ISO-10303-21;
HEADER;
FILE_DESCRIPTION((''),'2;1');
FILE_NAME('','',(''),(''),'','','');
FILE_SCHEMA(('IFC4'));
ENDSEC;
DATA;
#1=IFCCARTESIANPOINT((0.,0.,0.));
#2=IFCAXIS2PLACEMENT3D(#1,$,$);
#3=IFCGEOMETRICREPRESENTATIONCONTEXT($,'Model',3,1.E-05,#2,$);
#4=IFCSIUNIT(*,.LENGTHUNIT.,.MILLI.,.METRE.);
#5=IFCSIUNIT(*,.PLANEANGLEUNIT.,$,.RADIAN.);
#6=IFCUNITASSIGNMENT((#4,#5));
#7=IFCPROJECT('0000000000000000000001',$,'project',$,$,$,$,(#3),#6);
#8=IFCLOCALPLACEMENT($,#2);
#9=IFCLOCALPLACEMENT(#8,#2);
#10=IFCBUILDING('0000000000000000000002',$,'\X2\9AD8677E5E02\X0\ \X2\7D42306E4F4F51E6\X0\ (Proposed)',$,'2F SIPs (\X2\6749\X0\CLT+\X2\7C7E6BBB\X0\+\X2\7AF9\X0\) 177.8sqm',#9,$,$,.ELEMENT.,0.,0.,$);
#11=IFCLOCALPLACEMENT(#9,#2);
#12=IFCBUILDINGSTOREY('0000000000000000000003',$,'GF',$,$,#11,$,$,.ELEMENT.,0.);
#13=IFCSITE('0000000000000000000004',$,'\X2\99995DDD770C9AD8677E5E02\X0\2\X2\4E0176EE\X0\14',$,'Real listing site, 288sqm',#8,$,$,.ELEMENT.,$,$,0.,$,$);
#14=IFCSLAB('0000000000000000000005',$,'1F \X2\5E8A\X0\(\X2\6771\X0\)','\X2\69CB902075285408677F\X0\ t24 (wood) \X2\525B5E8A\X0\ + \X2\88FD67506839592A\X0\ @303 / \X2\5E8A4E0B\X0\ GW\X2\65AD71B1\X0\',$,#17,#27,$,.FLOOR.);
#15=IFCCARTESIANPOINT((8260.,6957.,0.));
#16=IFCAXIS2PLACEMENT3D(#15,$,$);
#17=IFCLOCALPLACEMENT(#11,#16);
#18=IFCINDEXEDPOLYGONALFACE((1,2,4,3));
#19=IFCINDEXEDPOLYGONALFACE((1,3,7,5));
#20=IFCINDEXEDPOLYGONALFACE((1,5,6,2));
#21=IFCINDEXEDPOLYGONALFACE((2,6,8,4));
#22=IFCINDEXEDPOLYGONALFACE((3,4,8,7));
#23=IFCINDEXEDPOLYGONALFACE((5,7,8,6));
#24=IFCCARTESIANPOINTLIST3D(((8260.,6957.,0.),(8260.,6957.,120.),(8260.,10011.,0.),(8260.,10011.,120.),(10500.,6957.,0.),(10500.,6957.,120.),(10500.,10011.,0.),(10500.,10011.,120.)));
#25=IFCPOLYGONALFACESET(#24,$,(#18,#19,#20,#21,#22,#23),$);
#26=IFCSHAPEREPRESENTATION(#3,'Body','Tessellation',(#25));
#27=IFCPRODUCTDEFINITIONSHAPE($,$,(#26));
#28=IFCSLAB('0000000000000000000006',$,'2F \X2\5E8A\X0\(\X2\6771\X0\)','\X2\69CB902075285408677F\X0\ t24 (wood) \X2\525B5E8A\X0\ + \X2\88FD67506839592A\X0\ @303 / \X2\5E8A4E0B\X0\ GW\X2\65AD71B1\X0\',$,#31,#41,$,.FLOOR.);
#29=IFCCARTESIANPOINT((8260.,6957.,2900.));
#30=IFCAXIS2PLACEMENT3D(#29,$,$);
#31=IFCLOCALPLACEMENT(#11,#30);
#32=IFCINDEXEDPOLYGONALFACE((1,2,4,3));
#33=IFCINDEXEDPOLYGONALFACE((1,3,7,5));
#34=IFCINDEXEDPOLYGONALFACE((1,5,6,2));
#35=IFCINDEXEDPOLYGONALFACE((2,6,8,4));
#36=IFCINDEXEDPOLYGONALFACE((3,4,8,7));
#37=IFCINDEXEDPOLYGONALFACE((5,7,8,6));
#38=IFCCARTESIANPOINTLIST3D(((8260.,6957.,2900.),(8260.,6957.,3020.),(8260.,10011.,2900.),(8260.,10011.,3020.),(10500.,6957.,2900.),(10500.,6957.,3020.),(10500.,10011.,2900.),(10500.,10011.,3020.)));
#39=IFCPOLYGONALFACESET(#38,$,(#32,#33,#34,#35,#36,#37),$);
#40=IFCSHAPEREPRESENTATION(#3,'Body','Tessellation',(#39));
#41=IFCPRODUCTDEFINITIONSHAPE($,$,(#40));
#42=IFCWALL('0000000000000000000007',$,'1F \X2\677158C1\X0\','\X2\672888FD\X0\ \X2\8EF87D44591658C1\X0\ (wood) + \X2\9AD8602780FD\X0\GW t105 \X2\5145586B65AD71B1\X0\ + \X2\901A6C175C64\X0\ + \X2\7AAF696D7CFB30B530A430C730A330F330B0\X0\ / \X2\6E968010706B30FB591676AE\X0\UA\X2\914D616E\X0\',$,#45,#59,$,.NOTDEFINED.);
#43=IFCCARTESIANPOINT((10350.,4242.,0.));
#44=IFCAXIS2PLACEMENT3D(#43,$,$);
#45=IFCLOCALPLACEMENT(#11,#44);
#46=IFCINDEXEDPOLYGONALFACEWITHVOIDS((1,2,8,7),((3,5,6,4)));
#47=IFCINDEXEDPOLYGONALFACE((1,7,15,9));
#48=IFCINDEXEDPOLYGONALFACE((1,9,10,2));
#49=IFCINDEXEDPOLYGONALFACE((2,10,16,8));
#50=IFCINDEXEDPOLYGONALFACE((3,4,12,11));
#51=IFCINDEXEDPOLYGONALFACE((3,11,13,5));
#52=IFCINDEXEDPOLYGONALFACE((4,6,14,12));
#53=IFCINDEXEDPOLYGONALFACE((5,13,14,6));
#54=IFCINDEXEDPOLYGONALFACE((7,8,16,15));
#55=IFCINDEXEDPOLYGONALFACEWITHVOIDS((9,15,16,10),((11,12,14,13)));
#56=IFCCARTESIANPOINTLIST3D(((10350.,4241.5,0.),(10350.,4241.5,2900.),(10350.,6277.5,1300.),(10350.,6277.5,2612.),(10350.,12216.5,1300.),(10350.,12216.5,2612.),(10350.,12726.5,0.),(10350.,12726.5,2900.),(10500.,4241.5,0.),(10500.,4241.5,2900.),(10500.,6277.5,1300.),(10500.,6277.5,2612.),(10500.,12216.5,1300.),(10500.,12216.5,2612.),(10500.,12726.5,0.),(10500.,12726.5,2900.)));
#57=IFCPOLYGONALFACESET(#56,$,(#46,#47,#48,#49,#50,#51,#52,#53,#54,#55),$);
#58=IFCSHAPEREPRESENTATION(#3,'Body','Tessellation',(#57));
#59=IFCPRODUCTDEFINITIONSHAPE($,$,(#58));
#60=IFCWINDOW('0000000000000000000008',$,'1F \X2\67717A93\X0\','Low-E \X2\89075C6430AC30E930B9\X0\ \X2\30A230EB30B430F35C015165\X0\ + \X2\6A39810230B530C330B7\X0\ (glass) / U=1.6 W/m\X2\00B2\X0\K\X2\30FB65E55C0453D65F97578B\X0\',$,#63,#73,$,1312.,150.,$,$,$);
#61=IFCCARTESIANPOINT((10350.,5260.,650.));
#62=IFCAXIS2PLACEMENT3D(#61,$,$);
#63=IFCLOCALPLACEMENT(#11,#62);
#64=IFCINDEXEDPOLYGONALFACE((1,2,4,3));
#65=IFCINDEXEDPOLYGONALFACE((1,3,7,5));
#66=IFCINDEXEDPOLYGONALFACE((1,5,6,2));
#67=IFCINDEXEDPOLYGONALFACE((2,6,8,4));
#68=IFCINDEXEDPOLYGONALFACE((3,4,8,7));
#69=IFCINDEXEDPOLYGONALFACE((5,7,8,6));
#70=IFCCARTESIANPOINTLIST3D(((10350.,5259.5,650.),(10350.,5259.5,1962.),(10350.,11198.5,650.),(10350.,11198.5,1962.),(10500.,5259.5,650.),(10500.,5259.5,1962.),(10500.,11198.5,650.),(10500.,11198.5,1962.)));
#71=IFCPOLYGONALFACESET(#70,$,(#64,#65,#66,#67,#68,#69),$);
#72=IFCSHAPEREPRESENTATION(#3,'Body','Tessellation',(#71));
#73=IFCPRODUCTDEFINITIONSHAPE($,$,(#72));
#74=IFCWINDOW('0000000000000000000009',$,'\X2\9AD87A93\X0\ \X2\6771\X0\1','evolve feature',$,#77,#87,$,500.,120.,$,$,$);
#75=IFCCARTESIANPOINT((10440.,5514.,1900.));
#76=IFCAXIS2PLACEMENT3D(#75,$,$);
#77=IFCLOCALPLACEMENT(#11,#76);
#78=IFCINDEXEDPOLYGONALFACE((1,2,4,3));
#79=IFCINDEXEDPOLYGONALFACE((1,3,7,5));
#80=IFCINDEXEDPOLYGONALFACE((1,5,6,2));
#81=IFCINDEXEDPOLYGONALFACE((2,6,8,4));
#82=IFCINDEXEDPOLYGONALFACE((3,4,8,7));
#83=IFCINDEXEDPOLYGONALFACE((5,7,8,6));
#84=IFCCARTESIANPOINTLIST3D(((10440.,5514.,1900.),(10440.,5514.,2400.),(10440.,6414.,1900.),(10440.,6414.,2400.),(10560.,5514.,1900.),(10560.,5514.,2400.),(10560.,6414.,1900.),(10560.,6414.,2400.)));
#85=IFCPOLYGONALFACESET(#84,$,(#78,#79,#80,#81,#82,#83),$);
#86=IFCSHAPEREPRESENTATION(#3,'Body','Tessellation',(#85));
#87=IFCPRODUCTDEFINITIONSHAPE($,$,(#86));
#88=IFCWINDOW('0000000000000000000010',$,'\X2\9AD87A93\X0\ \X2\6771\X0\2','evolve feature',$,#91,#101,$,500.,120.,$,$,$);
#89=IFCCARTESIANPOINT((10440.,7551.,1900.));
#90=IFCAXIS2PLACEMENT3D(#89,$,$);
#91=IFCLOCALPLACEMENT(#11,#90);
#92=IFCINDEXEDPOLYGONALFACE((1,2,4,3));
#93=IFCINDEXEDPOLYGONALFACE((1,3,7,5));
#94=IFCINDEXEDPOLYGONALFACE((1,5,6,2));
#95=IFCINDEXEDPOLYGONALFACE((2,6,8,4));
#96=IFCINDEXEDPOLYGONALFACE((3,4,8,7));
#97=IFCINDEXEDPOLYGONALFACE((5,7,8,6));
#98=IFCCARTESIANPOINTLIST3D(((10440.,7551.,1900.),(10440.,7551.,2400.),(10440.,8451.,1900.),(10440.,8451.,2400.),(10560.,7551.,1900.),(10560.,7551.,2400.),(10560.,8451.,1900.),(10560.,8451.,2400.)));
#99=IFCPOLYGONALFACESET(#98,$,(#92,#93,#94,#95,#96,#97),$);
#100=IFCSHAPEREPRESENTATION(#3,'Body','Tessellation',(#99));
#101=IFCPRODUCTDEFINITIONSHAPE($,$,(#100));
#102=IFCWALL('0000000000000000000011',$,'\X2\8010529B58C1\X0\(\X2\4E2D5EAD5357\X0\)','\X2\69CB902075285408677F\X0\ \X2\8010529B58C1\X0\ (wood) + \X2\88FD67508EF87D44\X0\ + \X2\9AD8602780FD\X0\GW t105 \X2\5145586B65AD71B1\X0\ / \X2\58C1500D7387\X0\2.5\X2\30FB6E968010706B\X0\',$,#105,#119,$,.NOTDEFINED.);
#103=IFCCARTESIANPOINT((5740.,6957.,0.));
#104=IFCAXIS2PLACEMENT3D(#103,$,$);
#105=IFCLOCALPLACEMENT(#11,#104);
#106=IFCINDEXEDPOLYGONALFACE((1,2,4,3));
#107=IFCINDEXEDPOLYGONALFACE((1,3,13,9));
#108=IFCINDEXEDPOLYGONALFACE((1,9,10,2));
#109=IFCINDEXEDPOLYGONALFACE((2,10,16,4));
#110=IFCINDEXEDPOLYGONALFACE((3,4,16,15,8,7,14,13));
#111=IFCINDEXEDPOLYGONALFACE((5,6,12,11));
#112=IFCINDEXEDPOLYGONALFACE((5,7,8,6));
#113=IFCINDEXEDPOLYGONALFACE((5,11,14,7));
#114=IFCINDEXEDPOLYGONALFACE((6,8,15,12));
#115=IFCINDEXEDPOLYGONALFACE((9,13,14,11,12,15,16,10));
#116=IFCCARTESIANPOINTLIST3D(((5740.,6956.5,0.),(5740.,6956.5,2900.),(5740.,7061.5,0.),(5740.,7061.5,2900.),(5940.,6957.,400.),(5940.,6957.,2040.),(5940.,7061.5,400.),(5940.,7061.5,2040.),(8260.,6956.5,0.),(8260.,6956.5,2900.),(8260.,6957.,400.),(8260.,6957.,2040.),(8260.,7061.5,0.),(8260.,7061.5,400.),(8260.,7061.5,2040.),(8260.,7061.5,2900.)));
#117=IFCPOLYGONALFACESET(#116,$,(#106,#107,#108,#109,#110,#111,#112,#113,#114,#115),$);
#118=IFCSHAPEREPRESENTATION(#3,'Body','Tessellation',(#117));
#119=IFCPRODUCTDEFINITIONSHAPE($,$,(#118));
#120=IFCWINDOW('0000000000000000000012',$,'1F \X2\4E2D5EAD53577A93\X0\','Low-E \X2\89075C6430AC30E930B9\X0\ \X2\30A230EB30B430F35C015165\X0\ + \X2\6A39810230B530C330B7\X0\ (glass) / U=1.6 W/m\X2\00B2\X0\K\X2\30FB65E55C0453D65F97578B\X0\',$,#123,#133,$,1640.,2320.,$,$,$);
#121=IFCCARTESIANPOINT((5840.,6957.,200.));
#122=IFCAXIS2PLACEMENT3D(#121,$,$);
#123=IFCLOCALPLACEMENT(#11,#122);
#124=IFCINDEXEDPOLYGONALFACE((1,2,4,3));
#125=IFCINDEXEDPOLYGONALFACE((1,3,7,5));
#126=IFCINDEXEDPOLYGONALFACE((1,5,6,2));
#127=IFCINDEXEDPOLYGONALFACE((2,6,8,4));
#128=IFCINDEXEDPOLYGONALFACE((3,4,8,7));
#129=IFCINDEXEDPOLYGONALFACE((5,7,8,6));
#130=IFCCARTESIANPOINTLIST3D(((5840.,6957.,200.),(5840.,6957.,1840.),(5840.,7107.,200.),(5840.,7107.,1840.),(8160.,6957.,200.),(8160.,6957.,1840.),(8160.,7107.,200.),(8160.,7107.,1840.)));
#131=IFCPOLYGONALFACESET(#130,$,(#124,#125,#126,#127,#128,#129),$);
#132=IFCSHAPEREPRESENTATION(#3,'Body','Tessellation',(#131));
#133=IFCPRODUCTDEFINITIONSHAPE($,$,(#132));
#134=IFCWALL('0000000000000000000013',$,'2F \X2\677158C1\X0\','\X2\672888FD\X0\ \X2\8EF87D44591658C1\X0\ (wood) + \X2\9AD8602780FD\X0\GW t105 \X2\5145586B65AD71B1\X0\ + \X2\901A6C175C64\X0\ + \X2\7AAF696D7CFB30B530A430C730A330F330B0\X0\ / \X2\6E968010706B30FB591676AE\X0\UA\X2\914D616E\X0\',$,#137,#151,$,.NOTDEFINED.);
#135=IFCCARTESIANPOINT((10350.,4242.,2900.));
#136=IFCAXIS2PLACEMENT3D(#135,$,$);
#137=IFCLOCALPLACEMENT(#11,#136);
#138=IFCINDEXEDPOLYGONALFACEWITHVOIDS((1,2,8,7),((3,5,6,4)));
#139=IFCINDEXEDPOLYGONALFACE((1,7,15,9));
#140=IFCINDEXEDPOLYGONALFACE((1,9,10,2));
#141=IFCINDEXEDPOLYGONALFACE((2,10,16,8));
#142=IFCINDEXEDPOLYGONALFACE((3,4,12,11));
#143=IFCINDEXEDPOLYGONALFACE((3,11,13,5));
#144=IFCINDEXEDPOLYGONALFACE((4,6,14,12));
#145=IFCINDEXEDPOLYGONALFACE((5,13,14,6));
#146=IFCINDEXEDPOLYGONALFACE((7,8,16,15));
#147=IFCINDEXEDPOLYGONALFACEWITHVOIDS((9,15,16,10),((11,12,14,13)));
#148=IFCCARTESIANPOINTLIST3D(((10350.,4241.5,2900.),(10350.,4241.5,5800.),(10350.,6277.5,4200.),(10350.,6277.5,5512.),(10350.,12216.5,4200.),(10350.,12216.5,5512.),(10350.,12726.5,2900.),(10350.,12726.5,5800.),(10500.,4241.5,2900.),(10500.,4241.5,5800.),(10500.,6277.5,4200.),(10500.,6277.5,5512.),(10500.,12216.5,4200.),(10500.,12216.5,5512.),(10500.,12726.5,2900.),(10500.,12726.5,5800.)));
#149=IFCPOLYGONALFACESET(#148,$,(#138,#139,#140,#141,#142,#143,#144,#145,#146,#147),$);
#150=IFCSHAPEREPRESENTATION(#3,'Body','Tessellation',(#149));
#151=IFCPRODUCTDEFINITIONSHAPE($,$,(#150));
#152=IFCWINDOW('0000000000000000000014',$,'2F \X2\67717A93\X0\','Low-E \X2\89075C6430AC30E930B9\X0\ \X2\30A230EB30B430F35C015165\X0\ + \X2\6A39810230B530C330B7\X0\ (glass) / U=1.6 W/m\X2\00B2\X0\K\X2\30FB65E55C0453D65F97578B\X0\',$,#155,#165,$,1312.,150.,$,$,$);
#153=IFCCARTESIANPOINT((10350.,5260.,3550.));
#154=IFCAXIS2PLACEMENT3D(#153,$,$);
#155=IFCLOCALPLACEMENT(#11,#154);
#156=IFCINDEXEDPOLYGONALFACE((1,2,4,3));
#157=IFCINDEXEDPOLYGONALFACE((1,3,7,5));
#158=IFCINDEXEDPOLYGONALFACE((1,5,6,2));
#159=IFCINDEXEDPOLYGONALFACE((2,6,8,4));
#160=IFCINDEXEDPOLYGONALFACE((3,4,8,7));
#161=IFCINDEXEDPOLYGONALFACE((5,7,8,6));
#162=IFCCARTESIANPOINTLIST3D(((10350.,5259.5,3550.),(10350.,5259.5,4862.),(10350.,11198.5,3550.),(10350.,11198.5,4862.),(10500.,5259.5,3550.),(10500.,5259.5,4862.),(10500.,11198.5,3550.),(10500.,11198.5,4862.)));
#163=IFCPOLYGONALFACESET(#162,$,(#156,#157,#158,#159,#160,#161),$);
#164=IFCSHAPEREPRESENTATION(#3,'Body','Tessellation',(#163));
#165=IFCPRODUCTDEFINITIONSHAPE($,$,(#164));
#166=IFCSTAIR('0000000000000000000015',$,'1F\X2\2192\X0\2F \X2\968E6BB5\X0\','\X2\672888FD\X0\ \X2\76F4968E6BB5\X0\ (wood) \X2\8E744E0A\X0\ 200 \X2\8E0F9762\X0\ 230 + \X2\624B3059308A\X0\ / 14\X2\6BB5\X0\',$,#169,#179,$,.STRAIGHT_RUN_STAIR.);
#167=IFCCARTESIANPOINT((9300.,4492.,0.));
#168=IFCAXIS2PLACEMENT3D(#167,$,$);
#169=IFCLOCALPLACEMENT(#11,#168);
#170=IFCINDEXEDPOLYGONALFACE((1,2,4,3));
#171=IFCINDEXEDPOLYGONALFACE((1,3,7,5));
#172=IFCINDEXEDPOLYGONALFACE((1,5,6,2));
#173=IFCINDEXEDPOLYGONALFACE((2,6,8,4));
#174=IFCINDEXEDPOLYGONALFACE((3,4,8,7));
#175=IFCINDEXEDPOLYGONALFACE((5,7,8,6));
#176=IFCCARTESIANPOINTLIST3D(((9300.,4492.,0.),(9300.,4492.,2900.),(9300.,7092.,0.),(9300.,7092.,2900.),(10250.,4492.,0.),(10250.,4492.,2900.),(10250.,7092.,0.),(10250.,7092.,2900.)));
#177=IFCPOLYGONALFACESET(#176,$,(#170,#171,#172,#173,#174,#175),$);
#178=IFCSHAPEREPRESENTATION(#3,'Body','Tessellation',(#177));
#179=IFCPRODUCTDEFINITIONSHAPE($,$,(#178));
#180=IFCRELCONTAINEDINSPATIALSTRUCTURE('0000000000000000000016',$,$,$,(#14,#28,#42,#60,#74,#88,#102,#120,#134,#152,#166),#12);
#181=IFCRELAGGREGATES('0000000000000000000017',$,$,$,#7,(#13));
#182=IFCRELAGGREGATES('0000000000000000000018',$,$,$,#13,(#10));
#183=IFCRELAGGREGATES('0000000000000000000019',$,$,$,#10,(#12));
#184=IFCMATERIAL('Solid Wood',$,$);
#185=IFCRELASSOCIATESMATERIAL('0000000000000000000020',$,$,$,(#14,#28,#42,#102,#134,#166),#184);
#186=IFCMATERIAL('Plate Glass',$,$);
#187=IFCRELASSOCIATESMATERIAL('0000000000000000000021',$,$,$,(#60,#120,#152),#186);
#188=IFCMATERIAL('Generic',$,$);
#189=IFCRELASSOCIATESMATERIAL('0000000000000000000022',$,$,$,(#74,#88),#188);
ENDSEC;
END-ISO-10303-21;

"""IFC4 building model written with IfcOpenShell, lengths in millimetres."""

from ifc_helpers import new_model, si_unit, frame, frame_2d, origin, place, context, project, spatial, rectangle, extrude, material, element, fill, save


model = new_model("IFC4")

# Units and contexts
model_context = context("Model", 3, precision=1e-05, world=origin())
ifc_project = project(units=[si_unit("LENGTHUNIT", "METRE", prefix="MILLI"), si_unit("PLANEANGLEUNIT", "RADIAN")], contexts=[model_context])

# Site, building, storey
site_placement = place(None, origin())
site = spatial("IfcSite", under=ifc_project, at=site_placement, Name="香川県高松市2丁目14", ObjectType="Real listing site, 288sqm", CompositionType="ELEMENT", RefElevation=0.0)
building_placement = place(site_placement, origin())
building = spatial("IfcBuilding", under=site, at=building_placement, Name="高松市 終の住処 (Proposed)", ObjectType="2F SIPs (杉CLT+籾殻+竹) 177.8sqm", CompositionType="ELEMENT", ElevationOfRefHeight=0.0, ElevationOfTerrain=0.0)
storey_placement = place(building_placement, origin())
storey = spatial("IfcBuildingStorey", under=building, at=storey_placement, Name="GF", CompositionType="ELEMENT", Elevation=0.0)

# Slabs
ifc_material_1 = material(Name="Solid Wood")
slab_1_placement = place(storey_placement, frame((8260.0, 6957.0, 0.0)))
element("IfcSlab", 1, at=slab_1_placement, inside=storey, material=ifc_material_1, Name="1F 床(東)", Description="構造用合板 t24 (wood) 剛床 + 製材根太 @303 / 床下 GW断熱", PredefinedType="FLOOR", context=model_context, shape_type="SweptSolid", body=[
    extrude(rectangle(XDim=2240.0, YDim=3054.0, at=frame_2d((1120.0, 1527.0))), frame((8260.0, 6957.0, 0.0)), (0.0, 0.0, 1.0), 120.0),
])
slab_2_placement = place(storey_placement, frame((8260.0, 6957.0, 2900.0)))
element("IfcSlab", 2, at=slab_2_placement, inside=storey, material=ifc_material_1, Name="2F 床(東)", Description="構造用合板 t24 (wood) 剛床 + 製材根太 @303 / 床下 GW断熱", PredefinedType="FLOOR", context=model_context, shape_type="SweptSolid", body=[
    extrude(rectangle(XDim=2240.0, YDim=3054.0, at=frame_2d((1120.0, 1527.0))), frame((8260.0, 6957.0, 2900.0)), (0.0, 0.0, 1.0), 120.0),
])

# Wall, openings, windows
wall_1_placement = place(storey_placement, frame((10350.0, 4242.0, 0.0)))
wall_1 = element("IfcWall", 3, at=wall_1_placement, inside=storey, material=ifc_material_1, Name="1F 東壁", Description="木製 軸組外壁 (wood) + 高性能GW t105 充填断熱 + 通気層 + 窯業系サイディング / 準耐火・外皮UA配慮", PredefinedType="NOTDEFINED", context=model_context, shape_type="SweptSolid", body=[
    extrude(rectangle(XDim=150.0, YDim=8485.0, at=frame_2d((75.0, 4242.0))), frame((10350.0, 4242.0, 0.0)), (0.0, 0.0, 1.0), 2900.0),
])
opening_1_placement = place(storey_placement, frame((10350.0, 5260.0, 650.0)))
opening_1 = element("IfcOpeningElement", 4, at=opening_1_placement, cuts=wall_1, PredefinedType="NOTDEFINED", context=model_context, shape_type="SweptSolid", body=[
    extrude(rectangle(XDim=150.0, YDim=5939.0, at=frame_2d((75.0, 2969.0))), frame((10350.0, 5260.0, 650.0)), (0.0, 0.0, 1.0), 1312.0),
])
opening_2_placement = place(storey_placement, frame((10440.0, 5514.0, 1900.0)))
opening_2 = element("IfcOpeningElement", 5, at=opening_2_placement, cuts=wall_1, PredefinedType="NOTDEFINED", context=model_context, shape_type="SweptSolid", body=[
    extrude(rectangle(XDim=120.0, YDim=900.0, at=frame_2d((60.0, 450.0))), frame((10440.0, 5514.0, 1900.0)), (0.0, 0.0, 1.0), 500.0),
])
opening_3_placement = place(storey_placement, frame((10440.0, 7551.0, 1900.0)))
opening_3 = element("IfcOpeningElement", 6, at=opening_3_placement, cuts=wall_1, PredefinedType="NOTDEFINED", context=model_context, shape_type="SweptSolid", body=[
    extrude(rectangle(XDim=120.0, YDim=900.0, at=frame_2d((60.0, 450.0))), frame((10440.0, 7551.0, 1900.0)), (0.0, 0.0, 1.0), 500.0),
])
ifc_material_2 = material(Name="Plate Glass")
window_1_placement = place(storey_placement, frame((10350.0, 5260.0, 650.0)))
window_1 = element("IfcWindow", 7, at=window_1_placement, inside=storey, material=ifc_material_2, Name="1F 東窓", Description="Low-E 複層ガラス アルゴン封入 + 樹脂サッシ (glass) / U=1.6 W/m²K・日射取得型", OverallHeight=1312.0, OverallWidth=150.0, context=model_context, shape_type="SweptSolid", body=[
    extrude(rectangle(XDim=150.0, YDim=5939.0, at=frame_2d((75.0, 2969.0))), frame((10350.0, 5260.0, 650.0)), (0.0, 0.0, 1.0), 1312.0),
])
fill(opening_1, window_1)
ifc_material_3 = material(Name="Generic")
window_2_placement = place(storey_placement, frame((10440.0, 5514.0, 1900.0)))
window_2 = element("IfcWindow", 8, at=window_2_placement, inside=storey, material=ifc_material_3, Name="高窓 東1", Description="evolve feature", OverallHeight=500.0, OverallWidth=120.0, context=model_context, shape_type="SweptSolid", body=[
    extrude(rectangle(XDim=120.0, YDim=900.0, at=frame_2d((60.0, 450.0))), frame((10440.0, 5514.0, 1900.0)), (0.0, 0.0, 1.0), 500.0),
])
fill(opening_2, window_2)
window_3_placement = place(storey_placement, frame((10440.0, 7551.0, 1900.0)))
window_3 = element("IfcWindow", 9, at=window_3_placement, inside=storey, material=ifc_material_3, Name="高窓 東2", Description="evolve feature", OverallHeight=500.0, OverallWidth=120.0, context=model_context, shape_type="SweptSolid", body=[
    extrude(rectangle(XDim=120.0, YDim=900.0, at=frame_2d((60.0, 450.0))), frame((10440.0, 7551.0, 1900.0)), (0.0, 0.0, 1.0), 500.0),
])
fill(opening_3, window_3)

# Wall, opening, window
wall_2_placement = place(storey_placement, frame((5740.0, 6957.0, 0.0)))
wall_2 = element("IfcWall", 10, at=wall_2_placement, inside=storey, material=ifc_material_1, Name="耐力壁(中庭南)", Description="構造用合板 耐力壁 (wood) + 製材軸組 + 高性能GW t105 充填断熱 / 壁倍率2.5・準耐火", PredefinedType="NOTDEFINED", context=model_context, shape_type="SweptSolid", body=[
    extrude(rectangle(XDim=2520.0, YDim=105.0, at=frame_2d((1260.0, 52.0))), frame((5740.0, 6957.0, 0.0)), (0.0, 0.0, 1.0), 2900.0),
])
opening_4_placement = place(storey_placement, frame((5840.0, 6957.0, 200.0)))
opening_4 = element("IfcOpeningElement", 11, at=opening_4_placement, cuts=wall_2, PredefinedType="NOTDEFINED", context=model_context, shape_type="SweptSolid", body=[
    extrude(rectangle(XDim=2320.0, YDim=150.0, at=frame_2d((1160.0, 75.0))), frame((5840.0, 6957.0, 200.0)), (0.0, 0.0, 1.0), 1640.0),
])
window_4_placement = place(storey_placement, frame((5840.0, 6957.0, 200.0)))
window_4 = element("IfcWindow", 12, at=window_4_placement, inside=storey, material=ifc_material_2, Name="1F 中庭南窓", Description="Low-E 複層ガラス アルゴン封入 + 樹脂サッシ (glass) / U=1.6 W/m²K・日射取得型", OverallHeight=1640.0, OverallWidth=2320.0, context=model_context, shape_type="SweptSolid", body=[
    extrude(rectangle(XDim=2320.0, YDim=150.0, at=frame_2d((1160.0, 75.0))), frame((5840.0, 6957.0, 200.0)), (0.0, 0.0, 1.0), 1640.0),
])
fill(opening_4, window_4)

# Wall, opening, window
wall_3_placement = place(storey_placement, frame((10350.0, 4242.0, 2900.0)))
wall_3 = element("IfcWall", 13, at=wall_3_placement, inside=storey, material=ifc_material_1, Name="2F 東壁", Description="木製 軸組外壁 (wood) + 高性能GW t105 充填断熱 + 通気層 + 窯業系サイディング / 準耐火・外皮UA配慮", PredefinedType="NOTDEFINED", context=model_context, shape_type="SweptSolid", body=[
    extrude(rectangle(XDim=150.0, YDim=8485.0, at=frame_2d((75.0, 4242.0))), frame((10350.0, 4242.0, 2900.0)), (0.0, 0.0, 1.0), 2900.0),
])
opening_5_placement = place(storey_placement, frame((10350.0, 5260.0, 3550.0)))
opening_5 = element("IfcOpeningElement", 14, at=opening_5_placement, cuts=wall_3, PredefinedType="NOTDEFINED", context=model_context, shape_type="SweptSolid", body=[
    extrude(rectangle(XDim=150.0, YDim=5939.0, at=frame_2d((75.0, 2969.0))), frame((10350.0, 5260.0, 3550.0)), (0.0, 0.0, 1.0), 1312.0),
])
window_5_placement = place(storey_placement, frame((10350.0, 5260.0, 3550.0)))
window_5 = element("IfcWindow", 15, at=window_5_placement, inside=storey, material=ifc_material_2, Name="2F 東窓", Description="Low-E 複層ガラス アルゴン封入 + 樹脂サッシ (glass) / U=1.6 W/m²K・日射取得型", OverallHeight=1312.0, OverallWidth=150.0, context=model_context, shape_type="SweptSolid", body=[
    extrude(rectangle(XDim=150.0, YDim=5939.0, at=frame_2d((75.0, 2969.0))), frame((10350.0, 5260.0, 3550.0)), (0.0, 0.0, 1.0), 1312.0),
])
fill(opening_5, window_5)

# Stair
stair_placement = place(storey_placement, frame((9300.0, 4492.0, 0.0)))
element("IfcStair", 16, at=stair_placement, inside=storey, material=ifc_material_1, Name="1F→2F 階段", Description="木製 直階段 (wood) 蹴上 200 踏面 230 + 手すり / 14段", PredefinedType="STRAIGHT_RUN_STAIR", context=model_context, shape_type="SweptSolid", body=[
    extrude(rectangle(XDim=950.0, YDim=2600.0, at=frame_2d((475.0, 1300.0))), frame((9300.0, 4492.0, 0.0)), (0.0, 0.0, 1.0), 2900.0),
])

save(model, "model.ifc")
